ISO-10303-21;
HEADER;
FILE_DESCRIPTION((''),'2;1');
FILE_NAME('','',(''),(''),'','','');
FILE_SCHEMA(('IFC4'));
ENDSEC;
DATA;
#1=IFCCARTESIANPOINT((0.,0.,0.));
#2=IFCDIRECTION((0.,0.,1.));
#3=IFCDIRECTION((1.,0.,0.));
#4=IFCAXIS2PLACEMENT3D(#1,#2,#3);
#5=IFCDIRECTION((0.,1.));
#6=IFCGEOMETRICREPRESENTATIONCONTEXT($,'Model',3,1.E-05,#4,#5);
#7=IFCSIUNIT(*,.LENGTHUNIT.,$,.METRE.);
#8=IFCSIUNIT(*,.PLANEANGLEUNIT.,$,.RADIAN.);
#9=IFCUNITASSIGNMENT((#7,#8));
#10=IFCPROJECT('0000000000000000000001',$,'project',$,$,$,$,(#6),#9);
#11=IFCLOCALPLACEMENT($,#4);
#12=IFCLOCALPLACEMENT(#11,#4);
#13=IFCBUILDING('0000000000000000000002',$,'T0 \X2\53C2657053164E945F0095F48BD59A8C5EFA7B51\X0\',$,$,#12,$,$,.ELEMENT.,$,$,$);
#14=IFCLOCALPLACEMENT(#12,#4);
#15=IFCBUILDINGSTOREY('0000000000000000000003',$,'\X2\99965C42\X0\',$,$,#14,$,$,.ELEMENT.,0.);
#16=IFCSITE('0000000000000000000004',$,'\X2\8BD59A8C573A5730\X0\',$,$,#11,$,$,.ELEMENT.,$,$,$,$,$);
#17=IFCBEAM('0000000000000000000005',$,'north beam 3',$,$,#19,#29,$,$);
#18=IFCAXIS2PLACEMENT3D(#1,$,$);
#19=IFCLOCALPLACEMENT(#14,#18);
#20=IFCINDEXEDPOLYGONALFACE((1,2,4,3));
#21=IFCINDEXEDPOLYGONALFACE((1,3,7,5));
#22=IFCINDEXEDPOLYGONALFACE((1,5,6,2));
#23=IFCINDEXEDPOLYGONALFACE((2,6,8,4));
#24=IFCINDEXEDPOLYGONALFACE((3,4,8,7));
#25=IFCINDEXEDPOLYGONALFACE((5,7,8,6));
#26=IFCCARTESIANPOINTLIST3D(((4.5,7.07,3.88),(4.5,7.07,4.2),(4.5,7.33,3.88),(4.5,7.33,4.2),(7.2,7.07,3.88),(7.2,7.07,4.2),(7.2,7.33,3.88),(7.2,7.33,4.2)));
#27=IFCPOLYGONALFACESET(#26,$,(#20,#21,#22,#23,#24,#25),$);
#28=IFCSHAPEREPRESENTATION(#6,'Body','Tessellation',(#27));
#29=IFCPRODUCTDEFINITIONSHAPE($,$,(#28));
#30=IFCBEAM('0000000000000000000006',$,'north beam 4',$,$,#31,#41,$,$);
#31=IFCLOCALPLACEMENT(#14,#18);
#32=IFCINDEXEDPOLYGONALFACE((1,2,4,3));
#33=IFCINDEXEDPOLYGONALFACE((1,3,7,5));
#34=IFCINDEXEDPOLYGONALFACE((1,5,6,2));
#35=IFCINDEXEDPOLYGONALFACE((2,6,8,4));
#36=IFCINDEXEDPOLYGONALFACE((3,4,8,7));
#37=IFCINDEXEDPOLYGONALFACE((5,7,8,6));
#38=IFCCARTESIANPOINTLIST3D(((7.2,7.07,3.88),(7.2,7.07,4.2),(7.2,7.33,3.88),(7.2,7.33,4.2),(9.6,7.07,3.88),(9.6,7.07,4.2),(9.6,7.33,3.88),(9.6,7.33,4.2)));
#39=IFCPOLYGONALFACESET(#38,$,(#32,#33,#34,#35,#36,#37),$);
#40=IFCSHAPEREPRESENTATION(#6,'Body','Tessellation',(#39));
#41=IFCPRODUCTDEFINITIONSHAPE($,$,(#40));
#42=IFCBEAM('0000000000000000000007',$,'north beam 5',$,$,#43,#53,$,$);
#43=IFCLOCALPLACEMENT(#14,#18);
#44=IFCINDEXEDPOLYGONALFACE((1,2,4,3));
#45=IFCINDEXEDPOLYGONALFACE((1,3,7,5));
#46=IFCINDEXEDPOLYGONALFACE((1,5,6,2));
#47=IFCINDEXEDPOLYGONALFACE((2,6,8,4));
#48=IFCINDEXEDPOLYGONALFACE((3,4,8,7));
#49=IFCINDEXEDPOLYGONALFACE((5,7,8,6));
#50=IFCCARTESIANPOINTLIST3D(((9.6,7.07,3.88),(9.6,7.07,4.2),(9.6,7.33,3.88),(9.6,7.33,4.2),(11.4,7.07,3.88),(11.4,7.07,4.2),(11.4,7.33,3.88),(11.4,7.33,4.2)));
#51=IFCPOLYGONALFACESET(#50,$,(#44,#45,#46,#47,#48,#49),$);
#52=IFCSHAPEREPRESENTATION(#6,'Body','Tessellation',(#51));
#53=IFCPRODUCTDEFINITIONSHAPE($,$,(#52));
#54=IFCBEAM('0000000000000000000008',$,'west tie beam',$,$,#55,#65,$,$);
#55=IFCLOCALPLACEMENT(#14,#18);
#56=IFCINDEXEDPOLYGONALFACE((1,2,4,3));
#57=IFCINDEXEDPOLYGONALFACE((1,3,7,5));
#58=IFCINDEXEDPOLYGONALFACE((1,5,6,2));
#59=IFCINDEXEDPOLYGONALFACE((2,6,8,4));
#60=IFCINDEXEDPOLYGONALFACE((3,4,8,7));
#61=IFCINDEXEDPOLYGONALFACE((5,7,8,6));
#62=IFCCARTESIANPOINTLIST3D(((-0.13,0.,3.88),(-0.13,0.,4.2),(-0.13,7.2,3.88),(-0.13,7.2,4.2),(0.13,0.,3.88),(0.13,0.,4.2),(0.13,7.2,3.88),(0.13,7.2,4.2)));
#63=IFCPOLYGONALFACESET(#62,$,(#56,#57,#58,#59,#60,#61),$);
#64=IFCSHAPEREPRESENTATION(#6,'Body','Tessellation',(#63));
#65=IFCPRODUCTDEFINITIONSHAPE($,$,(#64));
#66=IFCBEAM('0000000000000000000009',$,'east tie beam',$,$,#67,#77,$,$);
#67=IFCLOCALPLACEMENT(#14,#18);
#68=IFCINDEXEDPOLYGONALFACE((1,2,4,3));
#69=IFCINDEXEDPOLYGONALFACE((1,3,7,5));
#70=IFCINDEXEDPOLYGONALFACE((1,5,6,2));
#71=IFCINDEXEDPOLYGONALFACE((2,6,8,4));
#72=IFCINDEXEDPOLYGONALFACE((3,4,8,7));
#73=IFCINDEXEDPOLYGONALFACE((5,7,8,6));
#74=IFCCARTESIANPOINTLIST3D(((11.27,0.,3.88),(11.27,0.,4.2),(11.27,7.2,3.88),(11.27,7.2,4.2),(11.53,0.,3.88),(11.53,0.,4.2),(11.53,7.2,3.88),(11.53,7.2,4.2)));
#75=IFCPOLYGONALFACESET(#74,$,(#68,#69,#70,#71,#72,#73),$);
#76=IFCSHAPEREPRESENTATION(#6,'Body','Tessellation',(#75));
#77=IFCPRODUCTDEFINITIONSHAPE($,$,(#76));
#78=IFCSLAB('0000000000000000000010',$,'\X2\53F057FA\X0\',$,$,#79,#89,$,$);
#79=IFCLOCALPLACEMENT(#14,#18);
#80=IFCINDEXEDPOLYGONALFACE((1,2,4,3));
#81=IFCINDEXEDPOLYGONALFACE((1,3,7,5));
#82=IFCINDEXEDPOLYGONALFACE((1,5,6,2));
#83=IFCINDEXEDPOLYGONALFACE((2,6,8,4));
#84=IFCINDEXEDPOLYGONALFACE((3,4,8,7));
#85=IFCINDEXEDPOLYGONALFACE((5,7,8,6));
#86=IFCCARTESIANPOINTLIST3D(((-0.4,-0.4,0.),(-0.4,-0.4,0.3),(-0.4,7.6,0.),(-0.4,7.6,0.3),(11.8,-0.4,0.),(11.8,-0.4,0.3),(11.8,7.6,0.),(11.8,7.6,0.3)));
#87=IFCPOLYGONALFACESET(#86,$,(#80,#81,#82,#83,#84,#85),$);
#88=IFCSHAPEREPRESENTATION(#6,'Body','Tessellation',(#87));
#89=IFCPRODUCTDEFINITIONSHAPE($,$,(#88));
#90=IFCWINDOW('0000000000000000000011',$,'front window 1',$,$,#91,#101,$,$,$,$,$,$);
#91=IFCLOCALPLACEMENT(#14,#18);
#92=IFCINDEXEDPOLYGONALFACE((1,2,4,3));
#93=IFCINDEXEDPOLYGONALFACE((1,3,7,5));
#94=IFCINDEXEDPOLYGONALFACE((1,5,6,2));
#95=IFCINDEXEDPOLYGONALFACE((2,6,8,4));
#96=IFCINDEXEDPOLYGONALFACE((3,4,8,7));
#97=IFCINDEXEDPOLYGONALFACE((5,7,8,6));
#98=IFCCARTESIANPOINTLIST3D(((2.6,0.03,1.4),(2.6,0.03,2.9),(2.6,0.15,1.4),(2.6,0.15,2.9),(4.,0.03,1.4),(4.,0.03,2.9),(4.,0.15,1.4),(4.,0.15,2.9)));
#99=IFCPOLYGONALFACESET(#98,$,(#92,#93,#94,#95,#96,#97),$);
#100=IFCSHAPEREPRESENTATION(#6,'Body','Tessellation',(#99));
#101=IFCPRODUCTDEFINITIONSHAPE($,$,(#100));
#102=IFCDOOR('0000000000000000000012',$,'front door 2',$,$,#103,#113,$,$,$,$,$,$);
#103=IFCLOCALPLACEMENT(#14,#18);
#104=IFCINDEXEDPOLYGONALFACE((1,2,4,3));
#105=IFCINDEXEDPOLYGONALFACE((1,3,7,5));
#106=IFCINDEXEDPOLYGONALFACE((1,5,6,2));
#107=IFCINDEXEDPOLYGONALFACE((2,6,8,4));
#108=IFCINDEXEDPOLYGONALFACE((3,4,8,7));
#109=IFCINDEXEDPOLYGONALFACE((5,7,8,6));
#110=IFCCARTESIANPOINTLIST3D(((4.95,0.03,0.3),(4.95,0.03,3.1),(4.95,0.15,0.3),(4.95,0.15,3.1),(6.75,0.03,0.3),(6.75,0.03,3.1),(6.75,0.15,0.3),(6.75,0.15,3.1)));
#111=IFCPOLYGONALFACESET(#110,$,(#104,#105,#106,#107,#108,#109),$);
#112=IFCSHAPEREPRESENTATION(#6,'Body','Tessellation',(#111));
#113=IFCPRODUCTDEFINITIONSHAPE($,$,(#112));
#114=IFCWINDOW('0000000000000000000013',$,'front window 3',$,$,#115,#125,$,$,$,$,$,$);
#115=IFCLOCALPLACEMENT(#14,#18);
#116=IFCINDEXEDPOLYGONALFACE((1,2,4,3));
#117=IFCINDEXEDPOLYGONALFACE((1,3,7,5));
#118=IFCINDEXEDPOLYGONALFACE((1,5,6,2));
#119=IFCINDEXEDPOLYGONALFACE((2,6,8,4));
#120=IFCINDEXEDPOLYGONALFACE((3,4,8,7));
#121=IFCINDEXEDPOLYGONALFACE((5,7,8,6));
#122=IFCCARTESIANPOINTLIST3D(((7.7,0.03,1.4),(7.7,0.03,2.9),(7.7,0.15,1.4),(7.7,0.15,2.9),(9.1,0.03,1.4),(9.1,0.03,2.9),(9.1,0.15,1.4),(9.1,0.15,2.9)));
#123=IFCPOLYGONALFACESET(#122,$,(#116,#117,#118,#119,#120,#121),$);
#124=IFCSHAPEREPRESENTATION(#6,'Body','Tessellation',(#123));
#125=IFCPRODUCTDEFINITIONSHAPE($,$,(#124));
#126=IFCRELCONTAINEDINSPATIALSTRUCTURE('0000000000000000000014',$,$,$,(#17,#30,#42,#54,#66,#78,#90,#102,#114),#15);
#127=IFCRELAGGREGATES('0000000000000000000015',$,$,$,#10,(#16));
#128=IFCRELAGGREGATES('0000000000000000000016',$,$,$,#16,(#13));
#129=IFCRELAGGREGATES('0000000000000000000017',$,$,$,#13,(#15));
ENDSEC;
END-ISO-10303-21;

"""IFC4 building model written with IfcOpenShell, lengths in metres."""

from ifc_helpers import new_model, si_unit, direction, frame, origin_with_axes, origin_2d_with_axis, place, context, project, spatial, rectangle, extrude, element, save


model = new_model("IFC4")

# Units and contexts
model_context = context("Model", 3, precision=1e-05, world=origin_with_axes(), true_north=direction((0.0, 1.0)))
ifc_project = project(units=[si_unit("LENGTHUNIT", "METRE"), si_unit("PLANEANGLEUNIT", "RADIAN")], contexts=[model_context])

# Site, building, storey
site_placement = place(None, origin_with_axes())
site = spatial("IfcSite", under=ifc_project, at=site_placement, Name="试验场地", CompositionType="ELEMENT")
building_placement = place(site_placement, origin_with_axes())
building = spatial("IfcBuilding", under=site, at=building_placement, Name="T0 参数化五开间试验建筑", CompositionType="ELEMENT")
storey_placement = place(building_placement, origin_with_axes())
storey = spatial("IfcBuildingStorey", under=building, at=storey_placement, Name="首层", CompositionType="ELEMENT", Elevation=0.0)

# Beams
beam_1_placement = place(storey_placement, frame((5.85, 7.2, 3.88), z_axis=(0.0, 0.0, 1.0), x_axis=(1.0, 0.0, 0.0)))
element("IfcBeam", 1, at=beam_1_placement, inside=storey, Name="north beam 3", context=model_context, shape_type="SweptSolid", body=[
    extrude(rectangle(XDim=2.7, YDim=0.26, at=origin_2d_with_axis()), origin_with_axes(), (0.0, 0.0, 1.0), 0.32),
])
beam_2_placement = place(storey_placement, frame((8.4, 7.2, 3.88), z_axis=(0.0, 0.0, 1.0), x_axis=(1.0, 0.0, 0.0)))
element("IfcBeam", 2, at=beam_2_placement, inside=storey, Name="north beam 4", context=model_context, shape_type="SweptSolid", body=[
    extrude(rectangle(XDim=2.4, YDim=0.26, at=origin_2d_with_axis()), origin_with_axes(), (0.0, 0.0, 1.0), 0.32),
])
beam_3_placement = place(storey_placement, frame((10.5, 7.2, 3.88), z_axis=(0.0, 0.0, 1.0), x_axis=(1.0, 0.0, 0.0)))
element("IfcBeam", 3, at=beam_3_placement, inside=storey, Name="north beam 5", context=model_context, shape_type="SweptSolid", body=[
    extrude(rectangle(XDim=1.8, YDim=0.26, at=origin_2d_with_axis()), origin_with_axes(), (0.0, 0.0, 1.0), 0.32),
])
for number, where, z_axis, x_axis, name in (
    (4, (0.0, 3.6, 3.88), (0.0, 0.0, 1.0), (1.0, 0.0, 0.0), "west tie beam"),
    (5, (11.4, 3.6, 3.88), (0.0, 0.0, 1.0), (1.0, 0.0, 0.0), "east tie beam"),
):
    element("IfcBeam", number, at=place(storey_placement, frame(where, z_axis=z_axis, x_axis=x_axis)), inside=storey, Name=name, context=model_context, shape_type="SweptSolid", body=[
        extrude(rectangle(XDim=0.26, YDim=7.2, at=origin_2d_with_axis()), origin_with_axes(), (0.0, 0.0, 1.0), 0.32),
    ])

# Slab
slab_placement = place(storey_placement, frame((5.7, 3.6, 0.0), z_axis=(0.0, 0.0, 1.0), x_axis=(1.0, 0.0, 0.0)))
element("IfcSlab", 6, at=slab_placement, inside=storey, Name="台基", context=model_context, shape_type="SweptSolid", body=[
    extrude(rectangle(XDim=12.2, YDim=8.0, at=origin_2d_with_axis()), origin_with_axes(), (0.0, 0.0, 1.0), 0.3),
])

# Window
window_1_placement = place(storey_placement, frame((3.3, 0.09, 1.4), z_axis=(0.0, 0.0, 1.0), x_axis=(1.0, 0.0, 0.0)))
element("IfcWindow", 7, at=window_1_placement, inside=storey, Name="front window 1", context=model_context, shape_type="SweptSolid", body=[
    extrude(rectangle(XDim=1.4, YDim=0.12, at=origin_2d_with_axis()), origin_with_axes(), (0.0, 0.0, 1.0), 1.5),
])

# Door
door_placement = place(storey_placement, frame((5.85, 0.09, 0.3), z_axis=(0.0, 0.0, 1.0), x_axis=(1.0, 0.0, 0.0)))
element("IfcDoor", 8, at=door_placement, inside=storey, Name="front door 2", context=model_context, shape_type="SweptSolid", body=[
    extrude(rectangle(XDim=1.8, YDim=0.12, at=origin_2d_with_axis()), origin_with_axes(), (0.0, 0.0, 1.0), 2.8),
])

# Window
window_2_placement = place(storey_placement, frame((8.4, 0.09, 1.4), z_axis=(0.0, 0.0, 1.0), x_axis=(1.0, 0.0, 0.0)))
element("IfcWindow", 9, at=window_2_placement, inside=storey, Name="front window 3", context=model_context, shape_type="SweptSolid", body=[
    extrude(rectangle(XDim=1.4, YDim=0.12, at=origin_2d_with_axis()), origin_with_axes(), (0.0, 0.0, 1.0), 1.5),
])

save(model, "model.ifc")
